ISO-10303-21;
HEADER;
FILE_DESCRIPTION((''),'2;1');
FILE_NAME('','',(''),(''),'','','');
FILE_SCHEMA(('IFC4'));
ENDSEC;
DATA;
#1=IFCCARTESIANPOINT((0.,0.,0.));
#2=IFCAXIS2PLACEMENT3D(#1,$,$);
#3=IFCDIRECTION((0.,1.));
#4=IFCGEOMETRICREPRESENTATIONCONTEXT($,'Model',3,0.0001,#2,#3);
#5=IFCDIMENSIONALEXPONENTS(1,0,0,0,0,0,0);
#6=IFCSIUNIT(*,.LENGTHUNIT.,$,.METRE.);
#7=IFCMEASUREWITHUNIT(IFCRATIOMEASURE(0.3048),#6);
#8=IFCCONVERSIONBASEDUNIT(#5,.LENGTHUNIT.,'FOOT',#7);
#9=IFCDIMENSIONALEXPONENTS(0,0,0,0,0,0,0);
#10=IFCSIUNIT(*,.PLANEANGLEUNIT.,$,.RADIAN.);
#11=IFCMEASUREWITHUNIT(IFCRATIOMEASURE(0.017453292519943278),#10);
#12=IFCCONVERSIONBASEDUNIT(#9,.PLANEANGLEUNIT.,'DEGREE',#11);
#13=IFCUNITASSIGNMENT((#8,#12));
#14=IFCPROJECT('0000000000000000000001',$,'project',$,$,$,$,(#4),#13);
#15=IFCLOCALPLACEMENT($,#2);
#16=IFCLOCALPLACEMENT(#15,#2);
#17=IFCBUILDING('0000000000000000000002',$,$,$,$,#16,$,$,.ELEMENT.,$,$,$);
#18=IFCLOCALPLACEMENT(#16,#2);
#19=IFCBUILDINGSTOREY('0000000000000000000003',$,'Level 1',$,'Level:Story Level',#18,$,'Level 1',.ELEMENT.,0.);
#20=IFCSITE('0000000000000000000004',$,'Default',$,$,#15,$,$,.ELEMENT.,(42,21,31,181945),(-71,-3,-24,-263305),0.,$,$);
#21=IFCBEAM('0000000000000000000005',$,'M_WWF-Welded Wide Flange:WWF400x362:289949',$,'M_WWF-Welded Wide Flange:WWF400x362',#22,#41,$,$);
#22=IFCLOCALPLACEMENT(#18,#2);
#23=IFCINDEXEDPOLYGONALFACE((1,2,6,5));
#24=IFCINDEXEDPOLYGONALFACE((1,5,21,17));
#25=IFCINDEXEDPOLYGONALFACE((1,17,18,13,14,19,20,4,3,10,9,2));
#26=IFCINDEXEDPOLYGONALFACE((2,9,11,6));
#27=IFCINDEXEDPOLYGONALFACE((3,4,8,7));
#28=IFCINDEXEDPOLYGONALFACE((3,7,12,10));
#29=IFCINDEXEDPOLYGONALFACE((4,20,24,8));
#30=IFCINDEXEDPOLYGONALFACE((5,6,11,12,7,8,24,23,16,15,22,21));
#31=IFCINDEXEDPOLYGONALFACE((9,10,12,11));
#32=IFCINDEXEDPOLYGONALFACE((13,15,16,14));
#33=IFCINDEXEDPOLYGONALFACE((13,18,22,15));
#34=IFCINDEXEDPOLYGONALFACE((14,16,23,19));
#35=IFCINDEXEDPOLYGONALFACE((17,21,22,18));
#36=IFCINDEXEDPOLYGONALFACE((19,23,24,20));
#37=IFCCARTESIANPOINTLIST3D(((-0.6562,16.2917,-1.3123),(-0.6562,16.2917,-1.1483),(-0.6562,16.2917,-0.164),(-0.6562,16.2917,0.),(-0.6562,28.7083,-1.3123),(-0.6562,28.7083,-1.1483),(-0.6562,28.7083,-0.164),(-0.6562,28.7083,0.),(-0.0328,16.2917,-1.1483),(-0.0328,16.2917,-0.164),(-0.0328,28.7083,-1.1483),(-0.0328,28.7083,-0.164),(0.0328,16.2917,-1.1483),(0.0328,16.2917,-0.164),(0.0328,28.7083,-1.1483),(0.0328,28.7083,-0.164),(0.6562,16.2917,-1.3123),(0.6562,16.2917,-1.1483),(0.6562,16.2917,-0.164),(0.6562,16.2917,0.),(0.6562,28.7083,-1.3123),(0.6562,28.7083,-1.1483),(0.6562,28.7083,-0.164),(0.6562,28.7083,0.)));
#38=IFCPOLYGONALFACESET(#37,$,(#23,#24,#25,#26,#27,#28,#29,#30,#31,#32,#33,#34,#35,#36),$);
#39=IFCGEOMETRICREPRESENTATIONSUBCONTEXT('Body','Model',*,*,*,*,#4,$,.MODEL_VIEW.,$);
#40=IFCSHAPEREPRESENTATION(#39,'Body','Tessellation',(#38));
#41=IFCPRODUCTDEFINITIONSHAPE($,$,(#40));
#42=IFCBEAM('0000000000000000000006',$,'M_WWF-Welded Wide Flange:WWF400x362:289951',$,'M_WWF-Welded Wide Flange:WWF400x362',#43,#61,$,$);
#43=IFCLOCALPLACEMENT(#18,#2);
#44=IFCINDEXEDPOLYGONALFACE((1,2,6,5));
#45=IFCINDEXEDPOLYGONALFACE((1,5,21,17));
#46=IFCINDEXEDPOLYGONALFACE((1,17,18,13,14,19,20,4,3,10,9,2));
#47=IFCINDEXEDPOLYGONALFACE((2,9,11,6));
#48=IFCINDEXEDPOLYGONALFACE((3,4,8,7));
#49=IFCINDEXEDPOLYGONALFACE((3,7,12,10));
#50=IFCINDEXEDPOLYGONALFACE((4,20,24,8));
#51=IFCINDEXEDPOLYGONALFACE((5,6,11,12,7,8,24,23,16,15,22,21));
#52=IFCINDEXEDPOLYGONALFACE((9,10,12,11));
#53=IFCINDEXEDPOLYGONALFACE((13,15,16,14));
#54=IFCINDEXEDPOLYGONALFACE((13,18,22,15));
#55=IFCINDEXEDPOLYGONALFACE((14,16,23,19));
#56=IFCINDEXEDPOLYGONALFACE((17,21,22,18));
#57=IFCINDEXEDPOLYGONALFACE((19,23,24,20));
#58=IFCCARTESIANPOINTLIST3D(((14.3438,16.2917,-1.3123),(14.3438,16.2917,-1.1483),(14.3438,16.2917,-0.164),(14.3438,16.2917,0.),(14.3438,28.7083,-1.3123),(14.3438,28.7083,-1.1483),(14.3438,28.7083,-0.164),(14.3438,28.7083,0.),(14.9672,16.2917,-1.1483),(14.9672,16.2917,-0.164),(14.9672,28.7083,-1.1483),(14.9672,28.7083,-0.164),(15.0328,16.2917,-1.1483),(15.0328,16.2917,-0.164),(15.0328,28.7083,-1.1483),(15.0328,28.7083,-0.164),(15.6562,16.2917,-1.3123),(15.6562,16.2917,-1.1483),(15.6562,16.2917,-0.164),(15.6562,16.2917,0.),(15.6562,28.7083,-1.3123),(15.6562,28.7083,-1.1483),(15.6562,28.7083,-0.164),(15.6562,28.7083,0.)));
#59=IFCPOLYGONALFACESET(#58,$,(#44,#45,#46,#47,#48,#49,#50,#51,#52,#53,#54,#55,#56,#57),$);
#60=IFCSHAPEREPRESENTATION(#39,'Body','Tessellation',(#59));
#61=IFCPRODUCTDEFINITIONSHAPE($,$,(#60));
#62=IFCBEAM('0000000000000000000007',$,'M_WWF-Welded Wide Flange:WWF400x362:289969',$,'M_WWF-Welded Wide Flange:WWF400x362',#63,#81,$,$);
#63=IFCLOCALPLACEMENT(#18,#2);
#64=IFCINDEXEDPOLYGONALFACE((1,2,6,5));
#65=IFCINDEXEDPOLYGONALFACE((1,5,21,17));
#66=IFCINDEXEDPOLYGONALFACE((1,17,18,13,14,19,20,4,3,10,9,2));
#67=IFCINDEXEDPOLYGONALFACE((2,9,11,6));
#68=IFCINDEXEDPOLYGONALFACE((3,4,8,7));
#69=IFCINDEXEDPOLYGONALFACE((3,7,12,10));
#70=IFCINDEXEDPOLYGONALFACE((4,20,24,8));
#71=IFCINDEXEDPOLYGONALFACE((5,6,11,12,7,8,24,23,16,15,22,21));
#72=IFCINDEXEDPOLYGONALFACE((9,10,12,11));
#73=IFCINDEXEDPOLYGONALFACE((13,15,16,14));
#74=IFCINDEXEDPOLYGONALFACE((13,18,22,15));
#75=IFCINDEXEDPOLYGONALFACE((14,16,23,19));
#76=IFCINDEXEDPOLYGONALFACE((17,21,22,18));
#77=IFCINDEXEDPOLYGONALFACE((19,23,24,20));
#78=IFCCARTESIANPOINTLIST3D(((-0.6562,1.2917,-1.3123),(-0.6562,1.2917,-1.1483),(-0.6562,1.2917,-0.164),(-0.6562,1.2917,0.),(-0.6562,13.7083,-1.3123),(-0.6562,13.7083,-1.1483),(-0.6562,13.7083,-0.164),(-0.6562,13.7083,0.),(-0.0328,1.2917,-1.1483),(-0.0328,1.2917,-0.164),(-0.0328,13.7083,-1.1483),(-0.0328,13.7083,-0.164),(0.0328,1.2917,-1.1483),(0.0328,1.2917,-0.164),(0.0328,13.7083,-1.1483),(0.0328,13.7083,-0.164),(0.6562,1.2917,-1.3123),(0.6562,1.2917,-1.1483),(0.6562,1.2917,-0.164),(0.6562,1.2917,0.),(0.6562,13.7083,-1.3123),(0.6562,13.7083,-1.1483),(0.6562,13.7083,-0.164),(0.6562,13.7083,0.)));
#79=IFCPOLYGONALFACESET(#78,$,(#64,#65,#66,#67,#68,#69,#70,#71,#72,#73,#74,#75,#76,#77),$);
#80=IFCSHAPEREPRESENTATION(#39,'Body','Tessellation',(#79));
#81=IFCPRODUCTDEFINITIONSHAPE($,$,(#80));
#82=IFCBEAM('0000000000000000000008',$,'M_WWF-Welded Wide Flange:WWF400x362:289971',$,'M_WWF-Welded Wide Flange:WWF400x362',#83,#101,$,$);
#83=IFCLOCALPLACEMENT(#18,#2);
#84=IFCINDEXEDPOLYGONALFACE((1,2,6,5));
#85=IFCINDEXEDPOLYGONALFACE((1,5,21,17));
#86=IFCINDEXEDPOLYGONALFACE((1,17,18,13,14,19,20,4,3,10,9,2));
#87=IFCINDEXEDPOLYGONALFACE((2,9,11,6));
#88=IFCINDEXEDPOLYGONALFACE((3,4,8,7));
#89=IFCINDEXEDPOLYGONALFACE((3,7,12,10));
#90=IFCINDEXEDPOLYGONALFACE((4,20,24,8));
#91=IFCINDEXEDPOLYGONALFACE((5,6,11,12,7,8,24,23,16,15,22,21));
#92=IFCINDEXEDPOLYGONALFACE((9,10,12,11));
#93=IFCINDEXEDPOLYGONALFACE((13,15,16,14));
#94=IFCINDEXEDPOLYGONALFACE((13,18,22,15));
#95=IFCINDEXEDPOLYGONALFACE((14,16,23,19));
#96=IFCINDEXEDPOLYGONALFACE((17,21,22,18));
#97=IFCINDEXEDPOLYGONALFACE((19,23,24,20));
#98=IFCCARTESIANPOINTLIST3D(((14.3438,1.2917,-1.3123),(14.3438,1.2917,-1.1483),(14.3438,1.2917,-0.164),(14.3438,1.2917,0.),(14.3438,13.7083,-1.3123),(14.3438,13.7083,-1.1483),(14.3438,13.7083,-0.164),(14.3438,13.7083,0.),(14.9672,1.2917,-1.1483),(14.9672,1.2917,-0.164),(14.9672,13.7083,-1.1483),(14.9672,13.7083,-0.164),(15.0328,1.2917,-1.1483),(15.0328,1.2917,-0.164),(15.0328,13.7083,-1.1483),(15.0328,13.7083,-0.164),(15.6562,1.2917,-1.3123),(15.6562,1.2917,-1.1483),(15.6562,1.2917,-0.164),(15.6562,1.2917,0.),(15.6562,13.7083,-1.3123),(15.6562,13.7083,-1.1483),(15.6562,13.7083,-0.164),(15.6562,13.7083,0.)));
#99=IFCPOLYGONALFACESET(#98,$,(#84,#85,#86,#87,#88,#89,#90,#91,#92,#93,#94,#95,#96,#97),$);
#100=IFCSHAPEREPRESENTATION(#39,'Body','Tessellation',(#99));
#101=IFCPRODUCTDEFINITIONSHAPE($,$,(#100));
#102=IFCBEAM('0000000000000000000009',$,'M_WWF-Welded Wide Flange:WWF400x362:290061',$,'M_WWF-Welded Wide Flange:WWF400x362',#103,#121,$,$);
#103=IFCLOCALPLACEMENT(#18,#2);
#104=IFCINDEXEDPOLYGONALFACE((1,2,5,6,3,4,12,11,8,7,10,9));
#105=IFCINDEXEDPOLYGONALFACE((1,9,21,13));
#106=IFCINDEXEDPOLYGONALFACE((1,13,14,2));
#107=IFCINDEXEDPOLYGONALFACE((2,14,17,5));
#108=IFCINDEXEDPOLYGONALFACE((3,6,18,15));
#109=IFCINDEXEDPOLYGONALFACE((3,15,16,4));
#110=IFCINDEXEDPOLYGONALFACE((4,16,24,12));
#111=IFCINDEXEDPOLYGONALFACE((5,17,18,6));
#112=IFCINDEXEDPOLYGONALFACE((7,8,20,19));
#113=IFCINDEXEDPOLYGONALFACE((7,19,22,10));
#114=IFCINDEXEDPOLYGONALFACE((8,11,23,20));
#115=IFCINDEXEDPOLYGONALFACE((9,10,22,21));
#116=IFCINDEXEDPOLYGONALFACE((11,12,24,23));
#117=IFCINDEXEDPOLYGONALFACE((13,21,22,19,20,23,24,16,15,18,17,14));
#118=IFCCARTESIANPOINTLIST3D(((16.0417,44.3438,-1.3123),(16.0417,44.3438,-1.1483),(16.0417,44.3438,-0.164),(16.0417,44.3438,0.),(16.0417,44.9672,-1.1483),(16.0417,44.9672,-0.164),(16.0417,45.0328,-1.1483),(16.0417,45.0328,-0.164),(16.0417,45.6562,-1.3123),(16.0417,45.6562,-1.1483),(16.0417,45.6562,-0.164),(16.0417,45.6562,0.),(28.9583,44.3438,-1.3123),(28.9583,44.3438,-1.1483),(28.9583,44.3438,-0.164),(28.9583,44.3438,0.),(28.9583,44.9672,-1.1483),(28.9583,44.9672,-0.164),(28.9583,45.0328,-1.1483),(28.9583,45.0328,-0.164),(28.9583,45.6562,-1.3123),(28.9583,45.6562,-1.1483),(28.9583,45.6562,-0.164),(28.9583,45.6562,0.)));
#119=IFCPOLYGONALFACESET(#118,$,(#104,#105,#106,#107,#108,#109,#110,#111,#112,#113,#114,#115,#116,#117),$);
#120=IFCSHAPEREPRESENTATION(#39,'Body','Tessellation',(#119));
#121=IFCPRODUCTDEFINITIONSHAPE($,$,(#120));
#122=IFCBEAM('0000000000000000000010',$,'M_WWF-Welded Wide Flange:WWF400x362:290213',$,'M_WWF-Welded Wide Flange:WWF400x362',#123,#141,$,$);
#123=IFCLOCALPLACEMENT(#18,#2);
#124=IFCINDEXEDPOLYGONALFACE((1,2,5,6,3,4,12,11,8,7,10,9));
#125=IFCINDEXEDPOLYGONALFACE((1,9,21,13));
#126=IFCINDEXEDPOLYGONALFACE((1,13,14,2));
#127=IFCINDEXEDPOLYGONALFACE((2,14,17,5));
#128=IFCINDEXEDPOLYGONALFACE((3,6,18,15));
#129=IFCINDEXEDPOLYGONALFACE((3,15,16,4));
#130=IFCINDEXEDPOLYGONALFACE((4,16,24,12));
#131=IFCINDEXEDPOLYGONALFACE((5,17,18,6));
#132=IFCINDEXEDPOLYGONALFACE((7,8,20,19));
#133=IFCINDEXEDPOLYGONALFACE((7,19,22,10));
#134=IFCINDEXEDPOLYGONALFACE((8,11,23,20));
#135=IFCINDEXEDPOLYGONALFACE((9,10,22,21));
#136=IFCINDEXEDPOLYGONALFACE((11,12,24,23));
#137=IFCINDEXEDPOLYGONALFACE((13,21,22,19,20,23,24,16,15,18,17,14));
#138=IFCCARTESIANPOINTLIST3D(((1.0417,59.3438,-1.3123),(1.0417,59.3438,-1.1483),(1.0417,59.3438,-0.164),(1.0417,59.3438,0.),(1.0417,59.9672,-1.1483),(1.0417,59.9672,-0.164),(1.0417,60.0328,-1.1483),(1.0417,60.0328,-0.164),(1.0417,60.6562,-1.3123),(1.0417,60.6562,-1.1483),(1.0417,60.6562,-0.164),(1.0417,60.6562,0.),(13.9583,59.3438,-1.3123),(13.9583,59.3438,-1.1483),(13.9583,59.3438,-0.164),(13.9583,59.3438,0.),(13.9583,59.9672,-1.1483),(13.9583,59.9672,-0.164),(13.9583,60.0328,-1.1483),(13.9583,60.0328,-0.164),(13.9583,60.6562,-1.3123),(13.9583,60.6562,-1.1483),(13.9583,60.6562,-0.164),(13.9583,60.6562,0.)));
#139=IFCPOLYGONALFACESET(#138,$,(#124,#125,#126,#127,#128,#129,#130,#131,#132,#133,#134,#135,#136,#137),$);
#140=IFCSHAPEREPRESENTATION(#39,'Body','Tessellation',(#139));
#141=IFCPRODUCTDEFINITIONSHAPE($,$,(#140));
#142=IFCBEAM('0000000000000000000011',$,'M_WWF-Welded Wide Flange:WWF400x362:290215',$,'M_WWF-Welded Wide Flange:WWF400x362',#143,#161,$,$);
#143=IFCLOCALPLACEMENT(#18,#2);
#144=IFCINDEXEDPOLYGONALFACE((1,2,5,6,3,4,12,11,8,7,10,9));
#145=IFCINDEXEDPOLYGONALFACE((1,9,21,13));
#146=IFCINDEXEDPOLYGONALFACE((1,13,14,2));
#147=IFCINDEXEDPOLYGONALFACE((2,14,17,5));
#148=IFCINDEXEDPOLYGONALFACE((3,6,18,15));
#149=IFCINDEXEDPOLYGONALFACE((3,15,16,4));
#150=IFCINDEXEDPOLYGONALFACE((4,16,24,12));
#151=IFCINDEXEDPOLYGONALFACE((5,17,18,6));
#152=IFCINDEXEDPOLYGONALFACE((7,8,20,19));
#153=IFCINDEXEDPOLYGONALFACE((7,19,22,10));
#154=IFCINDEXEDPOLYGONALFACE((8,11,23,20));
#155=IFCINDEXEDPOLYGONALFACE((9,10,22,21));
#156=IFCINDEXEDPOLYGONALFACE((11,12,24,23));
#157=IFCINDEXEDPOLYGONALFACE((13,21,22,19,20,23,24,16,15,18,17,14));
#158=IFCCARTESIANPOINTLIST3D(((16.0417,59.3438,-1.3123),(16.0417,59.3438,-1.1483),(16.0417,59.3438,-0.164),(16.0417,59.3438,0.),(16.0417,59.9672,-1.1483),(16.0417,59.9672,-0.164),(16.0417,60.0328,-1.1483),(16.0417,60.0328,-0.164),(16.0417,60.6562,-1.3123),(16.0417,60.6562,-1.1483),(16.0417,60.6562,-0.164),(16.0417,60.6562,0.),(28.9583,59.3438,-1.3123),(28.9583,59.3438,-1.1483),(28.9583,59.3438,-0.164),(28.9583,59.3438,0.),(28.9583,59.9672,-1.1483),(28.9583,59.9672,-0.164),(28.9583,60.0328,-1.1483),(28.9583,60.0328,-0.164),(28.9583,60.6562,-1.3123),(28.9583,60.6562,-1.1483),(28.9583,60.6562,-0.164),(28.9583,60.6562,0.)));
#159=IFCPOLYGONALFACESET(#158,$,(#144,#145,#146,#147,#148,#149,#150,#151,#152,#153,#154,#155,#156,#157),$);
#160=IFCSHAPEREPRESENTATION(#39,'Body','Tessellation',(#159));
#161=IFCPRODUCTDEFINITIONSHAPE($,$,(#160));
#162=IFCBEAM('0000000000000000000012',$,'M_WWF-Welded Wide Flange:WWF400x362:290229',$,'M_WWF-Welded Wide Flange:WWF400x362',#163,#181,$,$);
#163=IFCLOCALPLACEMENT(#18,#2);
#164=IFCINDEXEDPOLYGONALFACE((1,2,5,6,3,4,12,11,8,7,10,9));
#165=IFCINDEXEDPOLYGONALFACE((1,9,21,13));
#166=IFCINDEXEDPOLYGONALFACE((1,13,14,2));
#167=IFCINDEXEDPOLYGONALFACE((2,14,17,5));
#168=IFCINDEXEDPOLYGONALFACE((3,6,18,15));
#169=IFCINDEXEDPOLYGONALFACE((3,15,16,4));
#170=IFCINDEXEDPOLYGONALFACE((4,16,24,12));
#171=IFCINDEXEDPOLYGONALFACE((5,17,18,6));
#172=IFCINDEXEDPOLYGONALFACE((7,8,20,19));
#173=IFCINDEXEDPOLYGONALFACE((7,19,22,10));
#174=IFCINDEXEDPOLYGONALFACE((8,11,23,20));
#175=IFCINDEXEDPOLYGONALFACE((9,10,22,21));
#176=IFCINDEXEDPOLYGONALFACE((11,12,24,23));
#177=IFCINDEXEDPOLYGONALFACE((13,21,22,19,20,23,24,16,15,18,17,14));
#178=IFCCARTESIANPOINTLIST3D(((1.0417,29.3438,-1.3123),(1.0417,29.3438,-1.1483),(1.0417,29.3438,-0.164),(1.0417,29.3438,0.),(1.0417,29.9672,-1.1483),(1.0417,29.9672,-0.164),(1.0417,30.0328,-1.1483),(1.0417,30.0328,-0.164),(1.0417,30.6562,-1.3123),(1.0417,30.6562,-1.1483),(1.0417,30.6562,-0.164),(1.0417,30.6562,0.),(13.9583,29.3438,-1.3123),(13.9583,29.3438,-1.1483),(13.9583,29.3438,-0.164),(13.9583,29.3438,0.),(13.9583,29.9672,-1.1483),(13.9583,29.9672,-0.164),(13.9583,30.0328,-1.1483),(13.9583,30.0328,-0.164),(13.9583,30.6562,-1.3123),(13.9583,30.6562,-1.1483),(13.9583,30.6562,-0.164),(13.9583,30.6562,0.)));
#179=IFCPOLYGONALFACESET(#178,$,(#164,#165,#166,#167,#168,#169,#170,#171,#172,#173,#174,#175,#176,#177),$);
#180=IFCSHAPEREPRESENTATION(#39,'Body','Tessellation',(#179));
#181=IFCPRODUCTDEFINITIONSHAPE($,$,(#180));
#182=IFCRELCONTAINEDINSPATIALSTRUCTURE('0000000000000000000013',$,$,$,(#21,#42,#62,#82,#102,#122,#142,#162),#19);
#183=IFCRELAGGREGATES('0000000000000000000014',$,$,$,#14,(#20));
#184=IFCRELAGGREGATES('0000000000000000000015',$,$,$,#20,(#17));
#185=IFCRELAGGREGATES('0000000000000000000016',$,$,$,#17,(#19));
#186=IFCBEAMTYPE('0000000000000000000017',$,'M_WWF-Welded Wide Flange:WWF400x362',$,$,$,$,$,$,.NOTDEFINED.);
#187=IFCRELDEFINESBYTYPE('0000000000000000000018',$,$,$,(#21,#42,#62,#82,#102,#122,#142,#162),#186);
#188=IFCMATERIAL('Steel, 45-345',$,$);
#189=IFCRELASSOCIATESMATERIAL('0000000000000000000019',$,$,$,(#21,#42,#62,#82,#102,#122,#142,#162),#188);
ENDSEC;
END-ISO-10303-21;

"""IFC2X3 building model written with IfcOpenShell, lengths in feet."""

from ifc_helpers import new_model, entity, si_unit, converted_unit, direction, frame, frame_2d, origin, place, context, subcontext, project, spatial, i_section, extrude, material, type_object, element, save


model = new_model("IFC2X3")

# Units and contexts
model_context = context("Model", 3, precision=0.0001, world=origin(), true_north=direction((0.0, 1.0)))
body_context = subcontext(model_context, "Body", "Model", "MODEL_VIEW")
ifc_project = project(units=[converted_unit("LENGTHUNIT", "FOOT", entity("IfcRatioMeasure", 0.3048), si_unit("LENGTHUNIT", "METRE"), dimensions=[1, 0, 0, 0, 0, 0, 0]), converted_unit("PLANEANGLEUNIT", "DEGREE", entity("IfcRatioMeasure", 0.017453292519943278), si_unit("PLANEANGLEUNIT", "RADIAN"), dimensions=[0, 0, 0, 0, 0, 0, 0])], contexts=[model_context])

# Site, building, storey
site_placement = place(None, origin())
site = spatial("IfcSite", under=ifc_project, at=site_placement, Name="Default", CompositionType="ELEMENT", RefLatitude=(42, 21, 31, 181945), RefLongitude=(-71, -3, -24, -263305), RefElevation=0.0)
building_placement = place(site_placement, origin())
building = spatial("IfcBuilding", under=site, at=building_placement, CompositionType="ELEMENT")
storey_placement = place(building_placement, origin())
storey = spatial("IfcBuildingStorey", under=building, at=storey_placement, Name="Level 1", ObjectType="Level:Story Level", LongName="Level 1", CompositionType="ELEMENT", Elevation=0.0)

# Shared definitions
ifc_material = material(Name="Steel, 45-345")

# Beams
beam_type = type_object("IfcBeamType", Name="M_WWF-Welded Wide Flange:WWF400x362", PredefinedType="NOTDEFINED")
beam_1_placement = place(storey_placement, frame((0.0, 15.0, 0.0), z_axis=(0.0, 0.0, 1.0), x_axis=(0.0, 1.0, 0.0)))
element("IfcBeam", 1, at=beam_1_placement, inside=storey, type_object=beam_type, material=ifc_material, Name="M_WWF-Welded Wide Flange:WWF400x362:289949", ObjectType="M_WWF-Welded Wide Flange:WWF400x362", context=body_context, shape_type="SweptSolid", body=[
    extrude(i_section(OverallWidth=1.3123, OverallDepth=1.3123, WebThickness=0.0656, FlangeThickness=0.164, at=frame_2d((0.0, 0.0), x_axis=(0.0, 1.0))), frame((1.2917, 0.0, -0.6562), z_axis=(1.0, 0.0, 0.0), x_axis=(0.0, 0.0, -1.0)), (0.0, 0.0, 1.0), 12.4167),
])
beam_2_placement = place(storey_placement, frame((15.0, 15.0, 0.0), z_axis=(0.0, 0.0, 1.0), x_axis=(0.0, 1.0, 0.0)))
element("IfcBeam", 2, at=beam_2_placement, inside=storey, type_object=beam_type, material=ifc_material, Name="M_WWF-Welded Wide Flange:WWF400x362:289951", ObjectType="M_WWF-Welded Wide Flange:WWF400x362", context=body_context, shape_type="SweptSolid", body=[
    extrude(i_section(OverallWidth=1.3123, OverallDepth=1.3123, WebThickness=0.0656, FlangeThickness=0.164, at=frame_2d((0.0, 0.0), x_axis=(0.0, 1.0))), frame((1.2917, 0.0, -0.6562), z_axis=(1.0, 0.0, 0.0), x_axis=(0.0, 0.0, -1.0)), (0.0, 0.0, 1.0), 12.4167),
])
beam_3_placement = place(storey_placement, frame((0.0, 0.0, 0.0), z_axis=(0.0, 0.0, 1.0), x_axis=(0.0, 1.0, 0.0)))
element("IfcBeam", 3, at=beam_3_placement, inside=storey, type_object=beam_type, material=ifc_material, Name="M_WWF-Welded Wide Flange:WWF400x362:289969", ObjectType="M_WWF-Welded Wide Flange:WWF400x362", context=body_context, shape_type="SweptSolid", body=[
    extrude(i_section(OverallWidth=1.3123, OverallDepth=1.3123, WebThickness=0.0656, FlangeThickness=0.164, at=frame_2d((0.0, 0.0), x_axis=(0.0, 1.0))), frame((1.2917, 0.0, -0.6562), z_axis=(1.0, 0.0, 0.0), x_axis=(0.0, 0.0, -1.0)), (0.0, 0.0, 1.0), 12.4167),
])
beam_4_placement = place(storey_placement, frame((15.0, 0.0, 0.0), z_axis=(0.0, 0.0, 1.0), x_axis=(0.0, 1.0, 0.0)))
element("IfcBeam", 4, at=beam_4_placement, inside=storey, type_object=beam_type, material=ifc_material, Name="M_WWF-Welded Wide Flange:WWF400x362:289971", ObjectType="M_WWF-Welded Wide Flange:WWF400x362", context=body_context, shape_type="SweptSolid", body=[
    extrude(i_section(OverallWidth=1.3123, OverallDepth=1.3123, WebThickness=0.0656, FlangeThickness=0.164, at=frame_2d((0.0, 0.0), x_axis=(0.0, 1.0))), frame((1.2917, 0.0, -0.6562), z_axis=(1.0, 0.0, 0.0), x_axis=(0.0, 0.0, -1.0)), (0.0, 0.0, 1.0), 12.4167),
])
beam_5_placement = place(storey_placement, frame((15.0, 45.0, 0.0)))
element("IfcBeam", 5, at=beam_5_placement, inside=storey, type_object=beam_type, material=ifc_material, Name="M_WWF-Welded Wide Flange:WWF400x362:290061", ObjectType="M_WWF-Welded Wide Flange:WWF400x362", context=body_context, shape_type="SweptSolid", body=[
    extrude(i_section(OverallWidth=1.3123, OverallDepth=1.3123, WebThickness=0.0656, FlangeThickness=0.164, at=frame_2d((0.0, 0.0), x_axis=(0.0, 1.0))), frame((1.0417, 0.0, -0.6562), z_axis=(1.0, 0.0, 0.0), x_axis=(0.0, 0.0, -1.0)), (0.0, 0.0, 1.0), 12.9167),
])
beam_6_placement = place(storey_placement, frame((0.0, 60.0, 0.0)))
element("IfcBeam", 6, at=beam_6_placement, inside=storey, type_object=beam_type, material=ifc_material, Name="M_WWF-Welded Wide Flange:WWF400x362:290213", ObjectType="M_WWF-Welded Wide Flange:WWF400x362", context=body_context, shape_type="SweptSolid", body=[
    extrude(i_section(OverallWidth=1.3123, OverallDepth=1.3123, WebThickness=0.0656, FlangeThickness=0.164, at=frame_2d((0.0, 0.0), x_axis=(0.0, 1.0))), frame((1.0417, 0.0, -0.6562), z_axis=(1.0, 0.0, 0.0), x_axis=(0.0, 0.0, -1.0)), (0.0, 0.0, 1.0), 12.9167),
])
beam_7_placement = place(storey_placement, frame((15.0, 60.0, 0.0)))
element("IfcBeam", 7, at=beam_7_placement, inside=storey, type_object=beam_type, material=ifc_material, Name="M_WWF-Welded Wide Flange:WWF400x362:290215", ObjectType="M_WWF-Welded Wide Flange:WWF400x362", context=body_context, shape_type="SweptSolid", body=[
    extrude(i_section(OverallWidth=1.3123, OverallDepth=1.3123, WebThickness=0.0656, FlangeThickness=0.164, at=frame_2d((0.0, 0.0), x_axis=(0.0, 1.0))), frame((1.0417, 0.0, -0.6562), z_axis=(1.0, 0.0, 0.0), x_axis=(0.0, 0.0, -1.0)), (0.0, 0.0, 1.0), 12.9167),
])
beam_8_placement = place(storey_placement, frame((0.0, 30.0, 0.0)))
element("IfcBeam", 8, at=beam_8_placement, inside=storey, type_object=beam_type, material=ifc_material, Name="M_WWF-Welded Wide Flange:WWF400x362:290229", ObjectType="M_WWF-Welded Wide Flange:WWF400x362", context=body_context, shape_type="SweptSolid", body=[
    extrude(i_section(OverallWidth=1.3123, OverallDepth=1.3123, WebThickness=0.0656, FlangeThickness=0.164, at=frame_2d((0.0, 0.0), x_axis=(0.0, 1.0))), frame((1.0417, 0.0, -0.6562), z_axis=(1.0, 0.0, 0.0), x_axis=(0.0, 0.0, -1.0)), (0.0, 0.0, 1.0), 12.9167),
])

save(model, "model.ifc")
